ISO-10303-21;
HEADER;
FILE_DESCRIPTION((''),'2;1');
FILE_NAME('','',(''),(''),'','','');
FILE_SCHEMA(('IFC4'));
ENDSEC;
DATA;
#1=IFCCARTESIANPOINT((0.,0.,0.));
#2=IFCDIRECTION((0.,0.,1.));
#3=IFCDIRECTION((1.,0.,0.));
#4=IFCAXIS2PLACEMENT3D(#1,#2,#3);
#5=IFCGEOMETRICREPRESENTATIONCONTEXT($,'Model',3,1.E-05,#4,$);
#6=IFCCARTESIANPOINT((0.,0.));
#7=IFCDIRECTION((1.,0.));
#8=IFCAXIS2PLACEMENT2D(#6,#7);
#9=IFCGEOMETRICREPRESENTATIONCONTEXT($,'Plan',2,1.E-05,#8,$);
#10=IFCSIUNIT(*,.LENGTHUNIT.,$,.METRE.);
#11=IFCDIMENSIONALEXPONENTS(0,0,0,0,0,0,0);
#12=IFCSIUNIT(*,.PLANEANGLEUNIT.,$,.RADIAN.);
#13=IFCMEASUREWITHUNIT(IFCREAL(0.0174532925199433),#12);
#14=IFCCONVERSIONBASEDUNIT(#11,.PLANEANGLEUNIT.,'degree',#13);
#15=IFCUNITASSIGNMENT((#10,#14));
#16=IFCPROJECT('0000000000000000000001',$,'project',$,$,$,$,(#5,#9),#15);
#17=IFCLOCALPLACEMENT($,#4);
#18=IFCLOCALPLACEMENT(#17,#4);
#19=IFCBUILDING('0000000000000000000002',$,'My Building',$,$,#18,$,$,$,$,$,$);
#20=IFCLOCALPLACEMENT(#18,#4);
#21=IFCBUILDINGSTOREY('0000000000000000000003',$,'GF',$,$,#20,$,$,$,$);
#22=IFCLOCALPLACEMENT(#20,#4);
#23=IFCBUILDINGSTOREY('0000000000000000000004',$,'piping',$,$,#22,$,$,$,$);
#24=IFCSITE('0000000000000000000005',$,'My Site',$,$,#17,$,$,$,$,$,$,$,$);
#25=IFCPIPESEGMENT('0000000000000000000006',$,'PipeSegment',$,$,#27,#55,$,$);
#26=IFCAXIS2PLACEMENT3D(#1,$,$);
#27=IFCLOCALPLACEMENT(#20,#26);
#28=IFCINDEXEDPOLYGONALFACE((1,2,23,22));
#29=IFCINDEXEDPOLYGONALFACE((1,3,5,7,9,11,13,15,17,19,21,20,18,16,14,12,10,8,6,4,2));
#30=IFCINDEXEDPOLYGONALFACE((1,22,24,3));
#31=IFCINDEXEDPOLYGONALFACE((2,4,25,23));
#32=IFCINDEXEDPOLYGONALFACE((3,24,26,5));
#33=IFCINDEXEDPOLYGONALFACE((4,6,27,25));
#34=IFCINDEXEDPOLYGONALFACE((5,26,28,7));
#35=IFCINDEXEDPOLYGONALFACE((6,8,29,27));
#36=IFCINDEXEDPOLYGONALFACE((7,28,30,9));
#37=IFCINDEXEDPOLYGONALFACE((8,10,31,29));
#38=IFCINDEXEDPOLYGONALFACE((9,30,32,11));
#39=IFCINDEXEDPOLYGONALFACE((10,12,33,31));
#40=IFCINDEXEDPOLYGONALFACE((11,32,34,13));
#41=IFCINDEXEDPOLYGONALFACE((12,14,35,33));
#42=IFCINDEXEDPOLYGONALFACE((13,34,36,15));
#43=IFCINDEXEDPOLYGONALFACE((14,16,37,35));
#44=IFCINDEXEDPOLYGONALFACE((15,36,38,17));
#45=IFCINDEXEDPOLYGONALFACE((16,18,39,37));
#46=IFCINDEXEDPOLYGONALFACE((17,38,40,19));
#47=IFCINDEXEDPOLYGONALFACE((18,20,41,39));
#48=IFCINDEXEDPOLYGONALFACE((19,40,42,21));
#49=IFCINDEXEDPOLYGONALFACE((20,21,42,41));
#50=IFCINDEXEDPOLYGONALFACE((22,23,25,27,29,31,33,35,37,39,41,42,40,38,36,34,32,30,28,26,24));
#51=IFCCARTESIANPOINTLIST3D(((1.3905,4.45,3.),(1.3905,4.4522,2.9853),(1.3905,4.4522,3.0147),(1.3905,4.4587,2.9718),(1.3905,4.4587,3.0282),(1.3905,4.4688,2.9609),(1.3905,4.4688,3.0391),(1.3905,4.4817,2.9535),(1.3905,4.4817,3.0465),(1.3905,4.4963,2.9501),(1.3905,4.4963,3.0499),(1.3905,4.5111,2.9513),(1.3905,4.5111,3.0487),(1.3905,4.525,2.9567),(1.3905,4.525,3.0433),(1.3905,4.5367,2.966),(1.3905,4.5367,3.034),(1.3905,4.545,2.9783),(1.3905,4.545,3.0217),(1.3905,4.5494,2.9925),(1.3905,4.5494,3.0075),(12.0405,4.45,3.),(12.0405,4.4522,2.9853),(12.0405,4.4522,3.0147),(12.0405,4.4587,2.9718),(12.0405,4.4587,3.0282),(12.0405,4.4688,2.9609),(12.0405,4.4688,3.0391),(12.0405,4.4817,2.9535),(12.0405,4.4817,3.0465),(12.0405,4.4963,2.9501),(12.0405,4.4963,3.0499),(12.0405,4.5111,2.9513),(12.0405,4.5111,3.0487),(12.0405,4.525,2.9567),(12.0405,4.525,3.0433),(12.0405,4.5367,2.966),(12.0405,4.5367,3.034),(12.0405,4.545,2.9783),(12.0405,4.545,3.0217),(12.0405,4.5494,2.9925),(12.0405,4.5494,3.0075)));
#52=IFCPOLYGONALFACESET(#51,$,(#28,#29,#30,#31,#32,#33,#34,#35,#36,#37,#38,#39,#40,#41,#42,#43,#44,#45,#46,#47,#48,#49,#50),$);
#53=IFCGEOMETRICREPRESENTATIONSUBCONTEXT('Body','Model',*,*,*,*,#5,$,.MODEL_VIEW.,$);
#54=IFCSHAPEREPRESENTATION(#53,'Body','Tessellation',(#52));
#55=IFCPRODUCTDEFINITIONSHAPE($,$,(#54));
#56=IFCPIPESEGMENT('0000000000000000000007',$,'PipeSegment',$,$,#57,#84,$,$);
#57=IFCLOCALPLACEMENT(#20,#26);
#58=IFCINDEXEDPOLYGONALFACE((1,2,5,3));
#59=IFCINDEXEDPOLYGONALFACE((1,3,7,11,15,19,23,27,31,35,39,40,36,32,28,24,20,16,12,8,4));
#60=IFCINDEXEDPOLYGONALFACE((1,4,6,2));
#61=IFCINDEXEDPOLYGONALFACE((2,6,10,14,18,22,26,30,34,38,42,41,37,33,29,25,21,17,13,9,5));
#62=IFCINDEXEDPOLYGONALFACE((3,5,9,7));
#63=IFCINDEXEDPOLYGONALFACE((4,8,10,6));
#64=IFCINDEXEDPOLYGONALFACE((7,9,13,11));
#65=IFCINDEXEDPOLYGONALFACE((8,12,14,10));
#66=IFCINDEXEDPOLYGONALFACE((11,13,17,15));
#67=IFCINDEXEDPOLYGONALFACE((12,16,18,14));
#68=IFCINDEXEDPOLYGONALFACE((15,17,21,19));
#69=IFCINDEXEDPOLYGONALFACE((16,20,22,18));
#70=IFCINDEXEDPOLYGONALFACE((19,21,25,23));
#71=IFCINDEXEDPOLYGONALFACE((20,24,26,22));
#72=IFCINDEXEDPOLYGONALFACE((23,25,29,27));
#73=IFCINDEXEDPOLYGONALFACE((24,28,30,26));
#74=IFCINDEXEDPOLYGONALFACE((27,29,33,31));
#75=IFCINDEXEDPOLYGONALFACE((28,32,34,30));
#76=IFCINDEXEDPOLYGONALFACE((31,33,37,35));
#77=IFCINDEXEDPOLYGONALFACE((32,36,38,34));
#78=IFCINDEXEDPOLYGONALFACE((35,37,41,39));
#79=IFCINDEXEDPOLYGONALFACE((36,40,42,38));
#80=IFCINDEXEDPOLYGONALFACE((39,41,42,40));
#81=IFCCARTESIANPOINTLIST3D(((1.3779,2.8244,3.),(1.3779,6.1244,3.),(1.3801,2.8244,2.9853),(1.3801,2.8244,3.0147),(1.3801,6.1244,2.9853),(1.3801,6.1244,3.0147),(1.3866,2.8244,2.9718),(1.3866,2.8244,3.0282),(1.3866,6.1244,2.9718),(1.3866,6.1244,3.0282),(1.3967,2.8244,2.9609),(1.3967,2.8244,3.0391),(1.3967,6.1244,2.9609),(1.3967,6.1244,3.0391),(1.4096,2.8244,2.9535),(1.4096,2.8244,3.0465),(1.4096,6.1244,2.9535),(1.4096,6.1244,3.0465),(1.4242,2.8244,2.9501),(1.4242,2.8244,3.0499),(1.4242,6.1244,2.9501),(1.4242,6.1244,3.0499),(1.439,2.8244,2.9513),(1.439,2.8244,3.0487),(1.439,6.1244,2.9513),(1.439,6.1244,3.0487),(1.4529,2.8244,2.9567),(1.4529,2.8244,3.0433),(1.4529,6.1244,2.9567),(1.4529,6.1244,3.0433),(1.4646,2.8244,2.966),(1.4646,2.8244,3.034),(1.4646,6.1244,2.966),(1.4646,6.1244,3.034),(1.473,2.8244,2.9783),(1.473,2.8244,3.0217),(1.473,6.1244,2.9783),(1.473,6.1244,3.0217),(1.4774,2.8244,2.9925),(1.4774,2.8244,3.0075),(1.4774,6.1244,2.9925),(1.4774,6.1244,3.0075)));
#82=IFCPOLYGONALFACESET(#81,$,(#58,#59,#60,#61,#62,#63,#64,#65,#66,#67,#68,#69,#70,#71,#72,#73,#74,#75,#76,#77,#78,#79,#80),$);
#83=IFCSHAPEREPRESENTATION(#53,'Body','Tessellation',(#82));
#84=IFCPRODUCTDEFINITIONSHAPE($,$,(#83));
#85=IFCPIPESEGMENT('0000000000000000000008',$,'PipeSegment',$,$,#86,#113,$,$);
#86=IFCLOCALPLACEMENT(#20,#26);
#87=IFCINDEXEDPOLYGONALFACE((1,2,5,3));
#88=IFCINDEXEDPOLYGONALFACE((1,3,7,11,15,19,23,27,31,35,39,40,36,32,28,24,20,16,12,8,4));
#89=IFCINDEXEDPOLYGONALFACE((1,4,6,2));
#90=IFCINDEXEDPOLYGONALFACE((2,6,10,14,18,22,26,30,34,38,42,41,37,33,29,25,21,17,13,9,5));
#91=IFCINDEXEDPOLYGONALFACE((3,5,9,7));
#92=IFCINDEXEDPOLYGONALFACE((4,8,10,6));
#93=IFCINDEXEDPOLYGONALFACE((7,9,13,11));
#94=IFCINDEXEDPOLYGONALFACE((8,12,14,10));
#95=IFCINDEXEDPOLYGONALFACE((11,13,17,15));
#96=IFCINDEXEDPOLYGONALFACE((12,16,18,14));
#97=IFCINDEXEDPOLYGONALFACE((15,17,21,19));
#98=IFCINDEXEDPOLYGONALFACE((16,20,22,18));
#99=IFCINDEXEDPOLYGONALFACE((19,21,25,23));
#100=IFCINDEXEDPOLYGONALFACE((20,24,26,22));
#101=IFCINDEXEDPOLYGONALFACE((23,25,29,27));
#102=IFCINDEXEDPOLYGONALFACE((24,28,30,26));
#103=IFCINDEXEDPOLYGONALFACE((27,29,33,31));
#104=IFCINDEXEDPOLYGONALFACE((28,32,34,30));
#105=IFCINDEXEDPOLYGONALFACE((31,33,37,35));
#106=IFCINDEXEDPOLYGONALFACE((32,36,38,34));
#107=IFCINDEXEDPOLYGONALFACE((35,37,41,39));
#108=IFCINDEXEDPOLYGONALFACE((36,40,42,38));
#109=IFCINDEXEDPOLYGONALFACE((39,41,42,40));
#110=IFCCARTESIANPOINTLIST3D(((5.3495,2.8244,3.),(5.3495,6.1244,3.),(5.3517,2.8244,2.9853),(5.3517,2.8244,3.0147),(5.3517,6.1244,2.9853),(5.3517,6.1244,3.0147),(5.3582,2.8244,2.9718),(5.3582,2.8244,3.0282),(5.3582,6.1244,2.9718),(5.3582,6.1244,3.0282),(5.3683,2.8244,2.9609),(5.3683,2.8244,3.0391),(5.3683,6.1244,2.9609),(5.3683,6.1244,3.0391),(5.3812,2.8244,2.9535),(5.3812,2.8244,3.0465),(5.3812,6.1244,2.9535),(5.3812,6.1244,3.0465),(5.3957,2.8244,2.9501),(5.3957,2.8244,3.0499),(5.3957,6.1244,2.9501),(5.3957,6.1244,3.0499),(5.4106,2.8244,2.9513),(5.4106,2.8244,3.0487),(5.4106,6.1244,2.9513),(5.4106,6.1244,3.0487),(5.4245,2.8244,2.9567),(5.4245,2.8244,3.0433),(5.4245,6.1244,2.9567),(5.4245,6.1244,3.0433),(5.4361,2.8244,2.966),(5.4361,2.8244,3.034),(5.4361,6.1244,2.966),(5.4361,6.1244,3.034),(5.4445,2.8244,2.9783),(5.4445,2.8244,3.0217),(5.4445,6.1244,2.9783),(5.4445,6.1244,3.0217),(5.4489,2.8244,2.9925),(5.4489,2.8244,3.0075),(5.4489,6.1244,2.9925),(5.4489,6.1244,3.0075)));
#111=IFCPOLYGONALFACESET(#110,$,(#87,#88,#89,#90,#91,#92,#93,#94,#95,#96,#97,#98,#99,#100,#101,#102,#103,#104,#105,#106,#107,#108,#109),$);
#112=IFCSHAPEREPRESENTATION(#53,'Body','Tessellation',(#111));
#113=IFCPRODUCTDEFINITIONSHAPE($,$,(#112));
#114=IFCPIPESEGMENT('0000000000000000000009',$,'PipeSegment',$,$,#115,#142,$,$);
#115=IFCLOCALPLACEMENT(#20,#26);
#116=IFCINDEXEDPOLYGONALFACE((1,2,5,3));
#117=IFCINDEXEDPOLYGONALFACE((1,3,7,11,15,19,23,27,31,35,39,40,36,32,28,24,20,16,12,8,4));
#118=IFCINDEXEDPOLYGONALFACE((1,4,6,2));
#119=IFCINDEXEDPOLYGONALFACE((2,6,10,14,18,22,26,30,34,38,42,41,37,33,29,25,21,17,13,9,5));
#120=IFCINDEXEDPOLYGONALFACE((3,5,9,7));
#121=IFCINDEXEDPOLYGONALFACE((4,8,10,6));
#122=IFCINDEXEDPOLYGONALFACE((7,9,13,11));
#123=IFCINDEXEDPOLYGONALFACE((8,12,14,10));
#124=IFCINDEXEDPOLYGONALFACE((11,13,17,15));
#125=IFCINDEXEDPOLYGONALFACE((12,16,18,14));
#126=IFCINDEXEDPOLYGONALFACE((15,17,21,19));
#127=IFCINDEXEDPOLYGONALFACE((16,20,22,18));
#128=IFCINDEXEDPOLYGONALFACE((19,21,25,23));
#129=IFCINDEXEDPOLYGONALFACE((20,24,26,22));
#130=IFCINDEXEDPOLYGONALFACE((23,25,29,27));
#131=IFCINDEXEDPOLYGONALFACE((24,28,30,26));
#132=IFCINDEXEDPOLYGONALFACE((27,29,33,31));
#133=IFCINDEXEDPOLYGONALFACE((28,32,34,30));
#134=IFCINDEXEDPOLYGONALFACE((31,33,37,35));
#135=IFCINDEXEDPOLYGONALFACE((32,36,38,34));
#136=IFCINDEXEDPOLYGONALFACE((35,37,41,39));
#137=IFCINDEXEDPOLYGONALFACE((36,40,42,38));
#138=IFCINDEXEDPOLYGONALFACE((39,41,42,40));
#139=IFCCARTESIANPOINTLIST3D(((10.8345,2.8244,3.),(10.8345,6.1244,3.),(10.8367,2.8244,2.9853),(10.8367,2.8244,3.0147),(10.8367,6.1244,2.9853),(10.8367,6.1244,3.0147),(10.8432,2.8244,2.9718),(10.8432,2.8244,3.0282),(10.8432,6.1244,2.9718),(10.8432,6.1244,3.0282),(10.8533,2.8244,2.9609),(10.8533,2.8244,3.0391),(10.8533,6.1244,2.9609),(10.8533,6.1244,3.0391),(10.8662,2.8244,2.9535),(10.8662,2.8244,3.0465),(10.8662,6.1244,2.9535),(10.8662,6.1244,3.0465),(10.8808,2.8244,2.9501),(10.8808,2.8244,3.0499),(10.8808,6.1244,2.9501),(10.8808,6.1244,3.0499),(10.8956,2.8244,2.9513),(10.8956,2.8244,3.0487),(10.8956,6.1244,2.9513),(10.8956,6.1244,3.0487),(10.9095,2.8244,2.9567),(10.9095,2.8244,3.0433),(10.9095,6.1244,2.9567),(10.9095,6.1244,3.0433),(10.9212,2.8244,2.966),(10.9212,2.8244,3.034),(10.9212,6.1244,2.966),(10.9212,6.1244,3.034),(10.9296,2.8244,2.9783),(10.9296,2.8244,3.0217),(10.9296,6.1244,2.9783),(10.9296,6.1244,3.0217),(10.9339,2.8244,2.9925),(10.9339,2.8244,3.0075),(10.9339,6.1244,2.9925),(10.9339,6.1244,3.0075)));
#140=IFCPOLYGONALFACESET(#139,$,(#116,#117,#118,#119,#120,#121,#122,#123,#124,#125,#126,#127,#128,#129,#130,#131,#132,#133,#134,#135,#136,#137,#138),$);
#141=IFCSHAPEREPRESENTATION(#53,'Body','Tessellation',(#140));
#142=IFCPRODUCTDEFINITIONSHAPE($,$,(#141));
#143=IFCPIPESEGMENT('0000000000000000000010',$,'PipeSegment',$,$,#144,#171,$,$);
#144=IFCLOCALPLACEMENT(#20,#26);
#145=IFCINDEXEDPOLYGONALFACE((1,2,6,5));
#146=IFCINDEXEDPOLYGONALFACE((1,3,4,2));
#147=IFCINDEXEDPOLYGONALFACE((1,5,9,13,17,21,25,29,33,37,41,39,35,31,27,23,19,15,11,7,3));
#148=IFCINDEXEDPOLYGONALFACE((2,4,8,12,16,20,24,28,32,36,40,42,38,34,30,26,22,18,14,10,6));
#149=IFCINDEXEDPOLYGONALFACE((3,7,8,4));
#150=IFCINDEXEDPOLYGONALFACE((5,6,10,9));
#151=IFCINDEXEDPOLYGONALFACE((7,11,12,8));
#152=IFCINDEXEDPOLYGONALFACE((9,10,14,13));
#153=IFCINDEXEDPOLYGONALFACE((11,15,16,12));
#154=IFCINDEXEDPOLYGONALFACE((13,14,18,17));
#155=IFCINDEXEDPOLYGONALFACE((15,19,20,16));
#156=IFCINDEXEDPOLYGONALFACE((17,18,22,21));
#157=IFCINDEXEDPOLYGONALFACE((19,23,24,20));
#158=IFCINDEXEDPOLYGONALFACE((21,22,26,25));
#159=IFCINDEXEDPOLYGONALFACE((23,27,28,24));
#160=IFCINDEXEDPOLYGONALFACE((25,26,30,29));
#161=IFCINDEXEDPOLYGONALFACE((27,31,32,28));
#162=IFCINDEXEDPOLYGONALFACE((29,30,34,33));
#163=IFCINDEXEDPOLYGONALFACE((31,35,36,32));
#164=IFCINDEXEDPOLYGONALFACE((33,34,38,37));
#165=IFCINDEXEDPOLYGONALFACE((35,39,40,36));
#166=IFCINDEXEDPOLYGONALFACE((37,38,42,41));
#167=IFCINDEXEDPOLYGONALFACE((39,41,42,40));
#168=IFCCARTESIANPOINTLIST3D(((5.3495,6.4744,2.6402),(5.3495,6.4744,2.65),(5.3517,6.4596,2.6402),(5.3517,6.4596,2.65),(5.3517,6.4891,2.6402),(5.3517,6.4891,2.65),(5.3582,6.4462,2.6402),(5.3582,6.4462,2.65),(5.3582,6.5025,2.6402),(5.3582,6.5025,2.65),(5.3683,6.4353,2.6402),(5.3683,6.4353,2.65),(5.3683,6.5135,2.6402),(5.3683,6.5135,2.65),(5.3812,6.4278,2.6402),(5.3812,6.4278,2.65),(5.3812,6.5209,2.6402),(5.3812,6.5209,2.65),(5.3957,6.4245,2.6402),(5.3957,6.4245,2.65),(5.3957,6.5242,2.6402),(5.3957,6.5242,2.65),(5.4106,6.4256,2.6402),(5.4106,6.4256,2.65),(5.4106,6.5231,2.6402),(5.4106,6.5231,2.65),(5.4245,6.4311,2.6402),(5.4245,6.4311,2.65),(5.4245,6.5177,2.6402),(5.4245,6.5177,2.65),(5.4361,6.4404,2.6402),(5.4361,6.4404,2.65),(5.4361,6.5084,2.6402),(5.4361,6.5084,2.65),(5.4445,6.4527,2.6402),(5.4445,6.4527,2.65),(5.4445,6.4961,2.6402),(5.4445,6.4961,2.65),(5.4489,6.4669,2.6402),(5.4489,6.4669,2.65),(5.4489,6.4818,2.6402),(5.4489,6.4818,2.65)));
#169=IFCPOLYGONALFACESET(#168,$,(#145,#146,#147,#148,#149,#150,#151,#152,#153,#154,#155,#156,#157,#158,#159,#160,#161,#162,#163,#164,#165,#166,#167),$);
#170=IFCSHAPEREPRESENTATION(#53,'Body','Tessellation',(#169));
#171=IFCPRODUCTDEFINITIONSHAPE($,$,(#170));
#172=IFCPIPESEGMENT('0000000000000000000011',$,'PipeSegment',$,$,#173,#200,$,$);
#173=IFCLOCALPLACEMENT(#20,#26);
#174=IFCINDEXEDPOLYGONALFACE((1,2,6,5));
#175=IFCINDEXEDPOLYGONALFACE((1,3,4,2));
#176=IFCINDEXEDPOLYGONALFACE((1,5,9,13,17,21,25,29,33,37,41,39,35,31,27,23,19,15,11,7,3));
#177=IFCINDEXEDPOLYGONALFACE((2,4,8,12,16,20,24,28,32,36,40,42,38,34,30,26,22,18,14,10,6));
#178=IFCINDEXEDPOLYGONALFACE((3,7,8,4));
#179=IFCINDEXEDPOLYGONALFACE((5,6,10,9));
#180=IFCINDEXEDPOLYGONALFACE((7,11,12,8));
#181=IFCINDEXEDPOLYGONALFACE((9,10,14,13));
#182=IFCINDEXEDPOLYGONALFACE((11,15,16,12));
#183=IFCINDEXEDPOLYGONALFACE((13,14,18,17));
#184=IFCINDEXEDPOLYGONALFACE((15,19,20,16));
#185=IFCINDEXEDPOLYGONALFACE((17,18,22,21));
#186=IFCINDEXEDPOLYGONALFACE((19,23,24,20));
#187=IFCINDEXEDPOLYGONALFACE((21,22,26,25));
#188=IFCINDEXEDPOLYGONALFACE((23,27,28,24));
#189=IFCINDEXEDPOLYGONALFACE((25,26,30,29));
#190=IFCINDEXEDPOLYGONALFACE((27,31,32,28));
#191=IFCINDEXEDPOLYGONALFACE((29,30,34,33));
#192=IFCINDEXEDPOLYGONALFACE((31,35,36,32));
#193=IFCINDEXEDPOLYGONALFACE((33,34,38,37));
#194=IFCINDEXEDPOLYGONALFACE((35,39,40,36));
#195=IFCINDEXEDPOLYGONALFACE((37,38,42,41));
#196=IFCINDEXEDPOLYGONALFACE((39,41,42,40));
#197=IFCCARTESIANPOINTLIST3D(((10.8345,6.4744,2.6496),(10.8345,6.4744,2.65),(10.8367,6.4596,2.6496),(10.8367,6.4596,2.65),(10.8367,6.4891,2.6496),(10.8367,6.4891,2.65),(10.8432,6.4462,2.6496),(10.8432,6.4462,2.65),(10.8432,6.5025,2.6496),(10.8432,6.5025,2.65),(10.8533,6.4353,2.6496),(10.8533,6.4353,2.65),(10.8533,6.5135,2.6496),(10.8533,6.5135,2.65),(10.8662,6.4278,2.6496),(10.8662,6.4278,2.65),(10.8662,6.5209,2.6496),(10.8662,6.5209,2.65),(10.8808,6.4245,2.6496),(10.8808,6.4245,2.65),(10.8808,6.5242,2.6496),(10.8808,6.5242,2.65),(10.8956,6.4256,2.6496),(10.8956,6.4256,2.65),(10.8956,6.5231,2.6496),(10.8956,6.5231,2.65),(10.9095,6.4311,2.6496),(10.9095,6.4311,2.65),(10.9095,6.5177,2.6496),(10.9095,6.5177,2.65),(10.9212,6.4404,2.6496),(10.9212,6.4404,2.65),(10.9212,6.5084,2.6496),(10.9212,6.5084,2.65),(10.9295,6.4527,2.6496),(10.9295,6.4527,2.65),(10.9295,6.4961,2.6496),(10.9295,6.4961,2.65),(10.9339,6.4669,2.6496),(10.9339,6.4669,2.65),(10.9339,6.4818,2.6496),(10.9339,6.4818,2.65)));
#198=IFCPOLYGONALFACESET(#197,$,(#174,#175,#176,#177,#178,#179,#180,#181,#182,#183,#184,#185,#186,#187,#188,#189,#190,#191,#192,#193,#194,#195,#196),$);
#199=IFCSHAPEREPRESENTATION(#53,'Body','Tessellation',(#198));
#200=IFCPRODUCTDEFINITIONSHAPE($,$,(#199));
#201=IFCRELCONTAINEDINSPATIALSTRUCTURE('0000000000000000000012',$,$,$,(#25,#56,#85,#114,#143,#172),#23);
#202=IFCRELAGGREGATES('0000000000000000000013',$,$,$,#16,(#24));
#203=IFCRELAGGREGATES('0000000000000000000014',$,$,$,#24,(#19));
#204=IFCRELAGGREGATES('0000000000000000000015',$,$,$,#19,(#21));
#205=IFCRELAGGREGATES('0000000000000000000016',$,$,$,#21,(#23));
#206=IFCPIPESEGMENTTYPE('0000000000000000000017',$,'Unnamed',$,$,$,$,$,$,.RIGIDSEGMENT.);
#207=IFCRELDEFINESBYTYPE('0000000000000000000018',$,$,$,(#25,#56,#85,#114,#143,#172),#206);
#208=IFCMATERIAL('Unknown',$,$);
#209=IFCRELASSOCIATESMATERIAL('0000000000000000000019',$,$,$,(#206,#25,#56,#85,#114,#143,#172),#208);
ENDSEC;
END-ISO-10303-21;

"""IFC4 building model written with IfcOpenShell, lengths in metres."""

from ifc_helpers import new_model, entity, si_unit, converted_unit, frame, origin_with_axes, origin_2d_with_axis, place, context, subcontext, project, spatial, circle, extrude, material, material_profile, profile_set, profile_usage, type_object, element, save


model = new_model("IFC4")

# Units and contexts
model_context = context("Model", 3, precision=1e-05, world=origin_with_axes())
plan_context = context("Plan", 2, precision=1e-05, world=origin_2d_with_axis())
body_context = subcontext(model_context, "Body", "Model", "MODEL_VIEW")
ifc_project = project(units=[si_unit("LENGTHUNIT", "METRE"), converted_unit("PLANEANGLEUNIT", "degree", entity("IfcReal", 0.0174532925199433), si_unit("PLANEANGLEUNIT", "RADIAN"), dimensions=[0, 0, 0, 0, 0, 0, 0])], contexts=[model_context, plan_context])

# Site, building, storeys
site_placement = place(None, origin_with_axes())
site = spatial("IfcSite", under=ifc_project, at=site_placement, Name="My Site")
building_placement = place(site_placement, origin_with_axes())
building = spatial("IfcBuilding", under=site, at=building_placement, Name="My Building")
storey_1_placement = place(building_placement, origin_with_axes())
storey_1 = spatial("IfcBuildingStorey", under=building, at=storey_1_placement, Name="GF")
storey_2_placement = place(storey_1_placement, origin_with_axes())
storey_2 = spatial("IfcBuildingStorey", under=storey_1, at=storey_2_placement, Name="piping")

# Pipe segments
ifc_material = material(Name="Unknown")
ifc_material_profile = material_profile(ifc_material, circle(Radius=0.05))
ifc_profile_set = profile_set([ifc_material_profile])
ifc_profile_usage_1 = profile_usage(ifc_profile_set, cardinal=5)
pipe_segment_type = type_object("IfcPipeSegmentType", Name="Unnamed", PredefinedType="RIGIDSEGMENT", material=ifc_profile_set)
pipe_segment_1_placement = place(storey_2_placement, frame((12.0405, 4.5, 3.0), z_axis=(-1.0, 0.0, 0.0), x_axis=(0.0, -1.0, 0.0)))
element("IfcPipeSegment", 1, at=pipe_segment_1_placement, inside=storey_2, type_object=pipe_segment_type, material=ifc_profile_usage_1, Name="PipeSegment", context=body_context, shape_type="SweptSolid", body=[
    extrude(circle(Radius=0.05), origin_with_axes(), (0.0, 0.0, 1.0), 10.65),
])
ifc_profile_usage_2 = profile_usage(ifc_profile_set, cardinal=5)
pipe_segment_2_placement = place(storey_2_placement, frame((1.4279, 2.8244, 3.0), z_axis=(0.0, 1.0, 0.0), x_axis=(-1.0, 0.0, 0.0)))
element("IfcPipeSegment", 2, at=pipe_segment_2_placement, inside=storey_2, type_object=pipe_segment_type, material=ifc_profile_usage_2, Name="PipeSegment", context=body_context, shape_type="SweptSolid", body=[
    extrude(circle(Radius=0.05), origin_with_axes(), (0.0, 0.0, 1.0), 3.3),
])
ifc_profile_usage_3 = profile_usage(ifc_profile_set, cardinal=5)
pipe_segment_3_placement = place(storey_2_placement, frame((5.3995, 2.8244, 3.0), z_axis=(0.0, 1.0, 0.0), x_axis=(-1.0, 0.0, 0.0)))
element("IfcPipeSegment", 3, at=pipe_segment_3_placement, inside=storey_2, type_object=pipe_segment_type, material=ifc_profile_usage_3, Name="PipeSegment", context=body_context, shape_type="SweptSolid", body=[
    extrude(circle(Radius=0.05), origin_with_axes(), (0.0, 0.0, 1.0), 3.3),
])
ifc_profile_usage_4 = profile_usage(ifc_profile_set, cardinal=5)
pipe_segment_4_placement = place(storey_2_placement, frame((10.8845, 2.8244, 3.0), z_axis=(0.0, 1.0, 0.0), x_axis=(-1.0, 0.0, 0.0)))
element("IfcPipeSegment", 4, at=pipe_segment_4_placement, inside=storey_2, type_object=pipe_segment_type, material=ifc_profile_usage_4, Name="PipeSegment", context=body_context, shape_type="SweptSolid", body=[
    extrude(circle(Radius=0.05), origin_with_axes(), (0.0, 0.0, 1.0), 3.3),
])
ifc_profile_usage_5 = profile_usage(ifc_profile_set, cardinal=5)
pipe_segment_5_placement = place(storey_2_placement, frame((5.3995, 6.4744, 2.65), z_axis=(0.0, 0.0, -1.0), x_axis=(-1.0, 0.0, 0.0)))
element("IfcPipeSegment", 5, at=pipe_segment_5_placement, inside=storey_2, type_object=pipe_segment_type, material=ifc_profile_usage_5, Name="PipeSegment", context=body_context, shape_type="SweptSolid", body=[
    extrude(circle(Radius=0.05), origin_with_axes(), (0.0, 0.0, 1.0), 0.0098),
])
ifc_profile_usage_6 = profile_usage(ifc_profile_set, cardinal=5)
pipe_segment_6_placement = place(storey_2_placement, frame((10.8845, 6.4744, 2.65), z_axis=(0.0, 0.0, -1.0), x_axis=(-1.0, 0.0, 0.0)))
element("IfcPipeSegment", 6, at=pipe_segment_6_placement, inside=storey_2, type_object=pipe_segment_type, material=ifc_profile_usage_6, Name="PipeSegment", context=body_context, shape_type="SweptSolid", body=[
    extrude(circle(Radius=0.05), origin_with_axes(), (0.0, 0.0, 1.0), 0.0004),
])

save(model, "model.ifc")
